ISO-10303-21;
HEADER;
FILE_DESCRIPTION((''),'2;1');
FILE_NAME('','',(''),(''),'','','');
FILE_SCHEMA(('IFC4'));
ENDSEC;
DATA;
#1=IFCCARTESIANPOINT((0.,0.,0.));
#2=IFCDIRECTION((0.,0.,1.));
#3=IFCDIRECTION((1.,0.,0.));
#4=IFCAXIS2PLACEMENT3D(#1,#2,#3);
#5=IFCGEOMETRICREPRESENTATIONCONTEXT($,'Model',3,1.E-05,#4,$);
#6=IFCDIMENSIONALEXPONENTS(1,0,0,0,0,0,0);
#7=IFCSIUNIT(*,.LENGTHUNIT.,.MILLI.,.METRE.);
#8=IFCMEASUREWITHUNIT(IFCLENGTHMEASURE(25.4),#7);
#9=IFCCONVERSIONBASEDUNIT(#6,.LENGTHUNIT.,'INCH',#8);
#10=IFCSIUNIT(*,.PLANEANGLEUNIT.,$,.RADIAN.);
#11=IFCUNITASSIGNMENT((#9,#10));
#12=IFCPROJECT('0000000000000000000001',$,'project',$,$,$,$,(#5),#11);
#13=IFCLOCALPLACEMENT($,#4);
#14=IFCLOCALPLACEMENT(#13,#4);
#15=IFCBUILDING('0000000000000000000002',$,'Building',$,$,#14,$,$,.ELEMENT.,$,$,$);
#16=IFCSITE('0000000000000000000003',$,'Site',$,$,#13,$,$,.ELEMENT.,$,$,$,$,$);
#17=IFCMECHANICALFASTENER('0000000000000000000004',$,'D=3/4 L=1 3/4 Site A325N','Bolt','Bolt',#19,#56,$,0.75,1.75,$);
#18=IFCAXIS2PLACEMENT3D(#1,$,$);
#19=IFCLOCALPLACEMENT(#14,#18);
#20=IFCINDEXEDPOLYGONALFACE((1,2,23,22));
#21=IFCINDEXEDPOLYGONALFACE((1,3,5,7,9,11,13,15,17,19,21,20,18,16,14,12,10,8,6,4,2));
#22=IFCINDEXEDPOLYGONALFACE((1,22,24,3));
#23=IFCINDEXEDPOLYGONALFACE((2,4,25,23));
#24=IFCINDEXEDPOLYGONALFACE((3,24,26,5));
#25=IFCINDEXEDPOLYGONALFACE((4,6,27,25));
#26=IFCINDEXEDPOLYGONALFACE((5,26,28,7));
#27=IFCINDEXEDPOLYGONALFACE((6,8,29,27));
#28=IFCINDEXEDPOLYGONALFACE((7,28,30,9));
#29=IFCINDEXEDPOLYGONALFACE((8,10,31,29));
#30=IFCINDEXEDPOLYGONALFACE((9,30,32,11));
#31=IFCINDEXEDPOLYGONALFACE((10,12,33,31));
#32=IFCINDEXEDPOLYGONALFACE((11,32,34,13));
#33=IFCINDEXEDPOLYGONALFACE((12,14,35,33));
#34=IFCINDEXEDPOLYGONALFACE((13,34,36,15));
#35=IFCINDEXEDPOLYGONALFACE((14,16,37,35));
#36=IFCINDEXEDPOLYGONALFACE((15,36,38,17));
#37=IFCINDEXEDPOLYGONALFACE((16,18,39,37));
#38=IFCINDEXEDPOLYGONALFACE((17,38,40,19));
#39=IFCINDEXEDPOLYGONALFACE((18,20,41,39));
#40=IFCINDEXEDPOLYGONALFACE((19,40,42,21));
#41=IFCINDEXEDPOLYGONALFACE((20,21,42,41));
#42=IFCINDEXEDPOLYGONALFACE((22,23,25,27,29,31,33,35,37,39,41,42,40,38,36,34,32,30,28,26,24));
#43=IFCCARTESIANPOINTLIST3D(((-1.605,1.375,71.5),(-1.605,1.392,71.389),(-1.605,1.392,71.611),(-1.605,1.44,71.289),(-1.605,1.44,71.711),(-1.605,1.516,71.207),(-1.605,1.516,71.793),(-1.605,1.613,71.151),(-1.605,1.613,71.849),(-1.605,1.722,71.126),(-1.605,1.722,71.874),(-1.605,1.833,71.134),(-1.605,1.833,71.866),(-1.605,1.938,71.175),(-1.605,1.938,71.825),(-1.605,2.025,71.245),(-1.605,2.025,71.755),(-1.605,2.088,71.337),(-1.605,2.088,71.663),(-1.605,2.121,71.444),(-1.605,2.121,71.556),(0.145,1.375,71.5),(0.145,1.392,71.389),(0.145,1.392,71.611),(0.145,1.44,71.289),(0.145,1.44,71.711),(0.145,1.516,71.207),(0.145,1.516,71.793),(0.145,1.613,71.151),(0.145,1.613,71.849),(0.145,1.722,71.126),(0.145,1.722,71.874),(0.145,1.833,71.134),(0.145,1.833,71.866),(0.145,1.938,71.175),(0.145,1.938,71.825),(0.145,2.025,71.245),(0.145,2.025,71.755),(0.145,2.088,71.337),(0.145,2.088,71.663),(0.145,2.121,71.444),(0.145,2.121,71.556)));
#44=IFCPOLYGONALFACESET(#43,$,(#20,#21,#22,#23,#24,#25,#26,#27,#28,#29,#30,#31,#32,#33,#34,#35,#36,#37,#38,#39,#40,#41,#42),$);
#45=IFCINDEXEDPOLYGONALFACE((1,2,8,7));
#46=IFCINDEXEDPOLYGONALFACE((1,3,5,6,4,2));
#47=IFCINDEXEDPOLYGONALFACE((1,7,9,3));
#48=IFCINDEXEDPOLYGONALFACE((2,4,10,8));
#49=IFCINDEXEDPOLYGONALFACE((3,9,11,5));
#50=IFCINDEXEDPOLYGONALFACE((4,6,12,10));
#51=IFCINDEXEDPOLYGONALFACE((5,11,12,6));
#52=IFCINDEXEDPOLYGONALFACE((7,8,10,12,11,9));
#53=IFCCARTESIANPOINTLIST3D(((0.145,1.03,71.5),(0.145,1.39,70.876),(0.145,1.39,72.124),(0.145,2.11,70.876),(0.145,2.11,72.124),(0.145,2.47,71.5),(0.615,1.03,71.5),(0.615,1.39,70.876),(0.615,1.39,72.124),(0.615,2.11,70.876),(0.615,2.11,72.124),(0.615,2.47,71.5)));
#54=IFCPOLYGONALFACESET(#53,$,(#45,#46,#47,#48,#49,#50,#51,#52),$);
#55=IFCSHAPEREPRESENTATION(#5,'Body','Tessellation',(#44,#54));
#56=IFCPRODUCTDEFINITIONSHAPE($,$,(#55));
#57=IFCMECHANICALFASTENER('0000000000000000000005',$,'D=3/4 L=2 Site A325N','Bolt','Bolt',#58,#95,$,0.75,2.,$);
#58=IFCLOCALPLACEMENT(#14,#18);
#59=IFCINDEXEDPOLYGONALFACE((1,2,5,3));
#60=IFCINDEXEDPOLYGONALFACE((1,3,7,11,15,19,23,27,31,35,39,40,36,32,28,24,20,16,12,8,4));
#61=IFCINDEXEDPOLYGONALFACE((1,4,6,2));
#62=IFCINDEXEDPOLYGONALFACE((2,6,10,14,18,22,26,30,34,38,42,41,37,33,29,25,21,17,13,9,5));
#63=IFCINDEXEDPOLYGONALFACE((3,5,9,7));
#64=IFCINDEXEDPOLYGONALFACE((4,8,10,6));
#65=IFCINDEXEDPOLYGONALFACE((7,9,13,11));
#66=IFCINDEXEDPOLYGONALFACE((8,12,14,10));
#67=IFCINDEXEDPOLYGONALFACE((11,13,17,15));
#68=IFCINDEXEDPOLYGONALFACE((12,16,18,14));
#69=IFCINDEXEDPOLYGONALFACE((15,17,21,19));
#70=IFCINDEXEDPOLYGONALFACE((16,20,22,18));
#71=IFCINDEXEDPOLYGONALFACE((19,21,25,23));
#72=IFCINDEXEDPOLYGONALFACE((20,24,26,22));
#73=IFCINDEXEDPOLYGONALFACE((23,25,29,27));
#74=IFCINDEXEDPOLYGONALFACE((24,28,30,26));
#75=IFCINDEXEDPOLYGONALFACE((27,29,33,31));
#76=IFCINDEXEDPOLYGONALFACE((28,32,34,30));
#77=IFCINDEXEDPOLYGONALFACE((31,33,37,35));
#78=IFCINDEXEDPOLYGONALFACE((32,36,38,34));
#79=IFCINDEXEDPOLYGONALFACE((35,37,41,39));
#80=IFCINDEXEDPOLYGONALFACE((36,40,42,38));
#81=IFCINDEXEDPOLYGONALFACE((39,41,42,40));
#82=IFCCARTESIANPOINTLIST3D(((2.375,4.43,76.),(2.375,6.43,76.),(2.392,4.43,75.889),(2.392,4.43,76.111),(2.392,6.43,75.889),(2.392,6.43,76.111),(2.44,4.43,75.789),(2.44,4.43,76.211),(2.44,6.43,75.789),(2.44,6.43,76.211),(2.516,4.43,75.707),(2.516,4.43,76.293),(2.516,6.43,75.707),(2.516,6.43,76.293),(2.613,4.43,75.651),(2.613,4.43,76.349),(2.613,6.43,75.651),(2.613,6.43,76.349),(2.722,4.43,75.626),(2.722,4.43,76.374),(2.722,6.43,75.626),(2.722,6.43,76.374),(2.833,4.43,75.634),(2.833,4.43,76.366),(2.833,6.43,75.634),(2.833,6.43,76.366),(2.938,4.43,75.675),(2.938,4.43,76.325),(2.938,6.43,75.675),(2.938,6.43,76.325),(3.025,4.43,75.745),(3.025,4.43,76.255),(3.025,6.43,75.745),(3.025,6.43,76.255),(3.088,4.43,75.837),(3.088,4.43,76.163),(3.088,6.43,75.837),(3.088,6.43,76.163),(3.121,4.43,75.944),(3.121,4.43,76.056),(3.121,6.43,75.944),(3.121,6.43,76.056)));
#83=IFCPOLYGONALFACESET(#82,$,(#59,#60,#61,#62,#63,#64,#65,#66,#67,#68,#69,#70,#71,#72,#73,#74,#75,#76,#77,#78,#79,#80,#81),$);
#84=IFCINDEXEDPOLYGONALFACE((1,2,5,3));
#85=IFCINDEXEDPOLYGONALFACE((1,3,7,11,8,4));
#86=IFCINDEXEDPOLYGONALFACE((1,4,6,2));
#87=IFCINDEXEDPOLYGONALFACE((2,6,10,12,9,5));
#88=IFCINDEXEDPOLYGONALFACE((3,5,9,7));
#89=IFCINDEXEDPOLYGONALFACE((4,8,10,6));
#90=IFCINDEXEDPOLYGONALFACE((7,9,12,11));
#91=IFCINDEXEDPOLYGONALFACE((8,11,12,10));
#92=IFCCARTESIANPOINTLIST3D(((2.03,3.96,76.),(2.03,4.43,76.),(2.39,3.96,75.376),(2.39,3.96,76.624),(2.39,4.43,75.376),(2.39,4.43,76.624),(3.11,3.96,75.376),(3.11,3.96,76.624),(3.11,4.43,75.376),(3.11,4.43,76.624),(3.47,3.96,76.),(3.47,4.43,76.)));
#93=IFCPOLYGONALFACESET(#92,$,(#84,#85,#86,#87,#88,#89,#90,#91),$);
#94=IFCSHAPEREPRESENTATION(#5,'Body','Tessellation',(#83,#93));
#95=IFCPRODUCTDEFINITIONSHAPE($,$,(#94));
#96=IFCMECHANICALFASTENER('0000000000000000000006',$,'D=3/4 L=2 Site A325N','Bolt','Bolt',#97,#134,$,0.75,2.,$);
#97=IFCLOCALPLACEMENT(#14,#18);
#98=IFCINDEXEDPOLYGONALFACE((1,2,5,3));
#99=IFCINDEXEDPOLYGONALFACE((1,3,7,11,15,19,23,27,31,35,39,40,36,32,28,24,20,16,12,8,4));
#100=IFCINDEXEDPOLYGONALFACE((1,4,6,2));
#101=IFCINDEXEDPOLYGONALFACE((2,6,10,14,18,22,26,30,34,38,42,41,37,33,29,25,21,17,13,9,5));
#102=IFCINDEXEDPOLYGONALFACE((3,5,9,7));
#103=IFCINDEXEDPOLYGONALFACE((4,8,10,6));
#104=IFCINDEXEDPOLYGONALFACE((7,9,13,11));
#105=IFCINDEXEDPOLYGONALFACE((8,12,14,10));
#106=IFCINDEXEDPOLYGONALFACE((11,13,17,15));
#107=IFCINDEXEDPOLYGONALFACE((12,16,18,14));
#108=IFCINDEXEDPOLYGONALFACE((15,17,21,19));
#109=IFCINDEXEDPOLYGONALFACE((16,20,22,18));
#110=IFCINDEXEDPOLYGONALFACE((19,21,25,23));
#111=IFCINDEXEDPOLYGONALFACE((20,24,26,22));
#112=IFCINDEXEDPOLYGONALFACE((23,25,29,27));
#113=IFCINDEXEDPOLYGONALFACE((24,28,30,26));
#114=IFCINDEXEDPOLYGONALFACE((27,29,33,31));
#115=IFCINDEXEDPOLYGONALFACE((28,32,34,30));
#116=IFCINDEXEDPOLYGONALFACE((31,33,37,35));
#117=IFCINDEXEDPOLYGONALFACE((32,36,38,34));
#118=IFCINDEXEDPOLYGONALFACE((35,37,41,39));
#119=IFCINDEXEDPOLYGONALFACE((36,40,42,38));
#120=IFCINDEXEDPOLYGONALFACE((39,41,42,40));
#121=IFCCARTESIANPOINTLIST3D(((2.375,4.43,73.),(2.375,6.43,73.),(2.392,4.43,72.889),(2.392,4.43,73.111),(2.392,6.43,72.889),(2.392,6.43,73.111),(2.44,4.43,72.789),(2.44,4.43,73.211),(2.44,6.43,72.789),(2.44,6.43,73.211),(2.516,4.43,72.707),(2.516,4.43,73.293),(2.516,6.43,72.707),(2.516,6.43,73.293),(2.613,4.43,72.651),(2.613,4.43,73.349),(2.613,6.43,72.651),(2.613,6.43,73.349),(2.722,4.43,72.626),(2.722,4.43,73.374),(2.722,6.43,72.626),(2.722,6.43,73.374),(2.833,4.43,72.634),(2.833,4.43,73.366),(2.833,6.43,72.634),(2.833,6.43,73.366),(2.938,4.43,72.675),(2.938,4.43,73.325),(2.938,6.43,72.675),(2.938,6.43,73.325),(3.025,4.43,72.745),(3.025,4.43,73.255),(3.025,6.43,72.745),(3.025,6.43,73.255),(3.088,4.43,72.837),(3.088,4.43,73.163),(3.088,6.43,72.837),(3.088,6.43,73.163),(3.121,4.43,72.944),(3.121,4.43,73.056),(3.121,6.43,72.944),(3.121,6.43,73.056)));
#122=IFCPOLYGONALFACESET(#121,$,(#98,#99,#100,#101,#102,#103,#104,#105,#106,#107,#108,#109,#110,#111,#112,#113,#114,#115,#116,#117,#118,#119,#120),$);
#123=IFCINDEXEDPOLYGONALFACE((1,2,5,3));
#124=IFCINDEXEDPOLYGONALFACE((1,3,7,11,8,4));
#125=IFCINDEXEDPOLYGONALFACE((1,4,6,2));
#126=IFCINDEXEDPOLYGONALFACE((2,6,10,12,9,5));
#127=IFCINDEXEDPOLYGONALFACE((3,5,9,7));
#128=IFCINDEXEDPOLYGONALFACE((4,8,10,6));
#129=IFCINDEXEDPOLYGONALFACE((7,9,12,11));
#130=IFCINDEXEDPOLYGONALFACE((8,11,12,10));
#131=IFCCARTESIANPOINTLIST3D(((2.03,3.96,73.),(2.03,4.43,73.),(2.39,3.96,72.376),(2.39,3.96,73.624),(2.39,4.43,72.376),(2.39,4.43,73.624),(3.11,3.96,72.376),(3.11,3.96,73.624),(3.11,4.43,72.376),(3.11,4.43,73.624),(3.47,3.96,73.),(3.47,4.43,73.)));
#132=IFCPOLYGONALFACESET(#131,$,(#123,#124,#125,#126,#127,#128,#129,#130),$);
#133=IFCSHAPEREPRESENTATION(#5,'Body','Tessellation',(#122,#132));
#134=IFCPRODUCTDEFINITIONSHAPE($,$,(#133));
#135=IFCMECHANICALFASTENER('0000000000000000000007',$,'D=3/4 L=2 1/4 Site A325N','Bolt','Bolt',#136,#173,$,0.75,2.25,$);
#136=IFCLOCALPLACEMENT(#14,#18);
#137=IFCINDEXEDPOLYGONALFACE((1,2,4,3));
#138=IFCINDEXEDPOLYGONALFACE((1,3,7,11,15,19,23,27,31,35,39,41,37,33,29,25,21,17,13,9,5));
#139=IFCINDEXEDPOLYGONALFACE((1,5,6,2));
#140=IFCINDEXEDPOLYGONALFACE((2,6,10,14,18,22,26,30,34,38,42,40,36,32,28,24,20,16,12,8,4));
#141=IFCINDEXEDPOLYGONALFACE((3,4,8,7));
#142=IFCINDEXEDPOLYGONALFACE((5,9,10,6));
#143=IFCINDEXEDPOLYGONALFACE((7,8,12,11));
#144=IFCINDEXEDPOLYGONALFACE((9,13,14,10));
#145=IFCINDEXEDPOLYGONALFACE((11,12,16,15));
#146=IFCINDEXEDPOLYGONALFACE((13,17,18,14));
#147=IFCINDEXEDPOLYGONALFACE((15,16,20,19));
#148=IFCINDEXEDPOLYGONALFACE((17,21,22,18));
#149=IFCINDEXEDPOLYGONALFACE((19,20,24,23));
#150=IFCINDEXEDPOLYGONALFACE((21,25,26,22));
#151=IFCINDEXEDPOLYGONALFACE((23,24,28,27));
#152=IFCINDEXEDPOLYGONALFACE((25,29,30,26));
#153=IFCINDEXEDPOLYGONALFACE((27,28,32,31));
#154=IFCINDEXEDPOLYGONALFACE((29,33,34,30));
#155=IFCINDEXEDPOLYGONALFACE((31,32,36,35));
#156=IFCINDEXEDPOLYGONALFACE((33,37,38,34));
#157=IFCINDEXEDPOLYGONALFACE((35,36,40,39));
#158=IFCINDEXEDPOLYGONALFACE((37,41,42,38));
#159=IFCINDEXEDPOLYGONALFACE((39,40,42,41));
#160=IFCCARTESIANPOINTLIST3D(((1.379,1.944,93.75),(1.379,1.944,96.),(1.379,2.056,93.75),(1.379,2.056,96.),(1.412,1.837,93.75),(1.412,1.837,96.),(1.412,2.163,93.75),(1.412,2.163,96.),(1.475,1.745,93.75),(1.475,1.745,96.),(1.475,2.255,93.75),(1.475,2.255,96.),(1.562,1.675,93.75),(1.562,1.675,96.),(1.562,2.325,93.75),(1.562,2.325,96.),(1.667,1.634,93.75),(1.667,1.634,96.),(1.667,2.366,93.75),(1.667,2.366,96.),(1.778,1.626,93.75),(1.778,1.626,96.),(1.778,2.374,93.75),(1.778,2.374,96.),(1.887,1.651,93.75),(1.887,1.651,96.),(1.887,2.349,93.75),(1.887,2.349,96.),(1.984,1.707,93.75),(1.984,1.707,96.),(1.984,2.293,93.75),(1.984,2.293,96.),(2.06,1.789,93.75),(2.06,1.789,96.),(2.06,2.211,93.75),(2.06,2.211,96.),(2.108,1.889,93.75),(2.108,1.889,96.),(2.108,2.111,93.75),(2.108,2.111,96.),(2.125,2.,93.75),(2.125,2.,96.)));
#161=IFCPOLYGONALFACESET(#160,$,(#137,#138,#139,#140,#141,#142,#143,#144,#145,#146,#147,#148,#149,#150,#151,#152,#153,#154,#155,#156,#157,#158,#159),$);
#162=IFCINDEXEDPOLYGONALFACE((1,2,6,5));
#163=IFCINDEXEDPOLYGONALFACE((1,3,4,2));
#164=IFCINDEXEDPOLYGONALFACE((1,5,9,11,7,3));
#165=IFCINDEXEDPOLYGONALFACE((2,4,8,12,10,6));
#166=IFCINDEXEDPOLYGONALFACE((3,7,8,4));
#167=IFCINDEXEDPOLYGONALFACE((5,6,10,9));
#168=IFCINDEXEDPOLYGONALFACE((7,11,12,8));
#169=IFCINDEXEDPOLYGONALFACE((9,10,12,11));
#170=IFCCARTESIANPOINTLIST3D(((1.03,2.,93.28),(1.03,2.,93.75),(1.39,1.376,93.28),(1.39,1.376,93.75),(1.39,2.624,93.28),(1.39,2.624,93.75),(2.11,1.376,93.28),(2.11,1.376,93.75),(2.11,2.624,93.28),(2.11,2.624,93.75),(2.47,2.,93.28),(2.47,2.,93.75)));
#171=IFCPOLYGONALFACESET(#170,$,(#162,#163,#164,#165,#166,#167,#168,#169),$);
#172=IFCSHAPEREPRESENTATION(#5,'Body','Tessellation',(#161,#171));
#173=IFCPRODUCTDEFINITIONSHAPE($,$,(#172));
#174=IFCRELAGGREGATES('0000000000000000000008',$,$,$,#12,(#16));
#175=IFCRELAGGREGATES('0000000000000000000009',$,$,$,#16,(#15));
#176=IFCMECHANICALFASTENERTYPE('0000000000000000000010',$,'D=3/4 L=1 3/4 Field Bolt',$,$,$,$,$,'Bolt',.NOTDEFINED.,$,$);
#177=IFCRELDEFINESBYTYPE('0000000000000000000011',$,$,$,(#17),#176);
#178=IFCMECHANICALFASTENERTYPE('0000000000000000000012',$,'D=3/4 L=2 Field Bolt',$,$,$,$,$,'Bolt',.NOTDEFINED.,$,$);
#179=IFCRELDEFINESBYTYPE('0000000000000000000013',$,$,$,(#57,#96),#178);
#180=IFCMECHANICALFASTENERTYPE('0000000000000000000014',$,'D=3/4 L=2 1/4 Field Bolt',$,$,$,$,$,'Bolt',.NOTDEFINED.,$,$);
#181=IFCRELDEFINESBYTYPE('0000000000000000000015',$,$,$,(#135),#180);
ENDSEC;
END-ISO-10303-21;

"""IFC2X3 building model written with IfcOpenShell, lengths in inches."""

from ifc_helpers import new_model, entity, si_unit, converted_unit, frame, origin_with_axes, origin_2d_with_axis, place, context, project, spatial, polyline, circle, outline, extrude, source, transform, mapped, type_object, type_shapes, element, save


model = new_model("IFC2X3")

# Units and contexts
model_context = context("Model", 3, precision=1e-05, world=origin_with_axes())
ifc_project = project(units=[converted_unit("LENGTHUNIT", "INCH", entity("IfcLengthMeasure", 25.4), si_unit("LENGTHUNIT", "METRE", prefix="MILLI"), dimensions=[1, 0, 0, 0, 0, 0, 0]), si_unit("PLANEANGLEUNIT", "RADIAN")], contexts=[model_context])

# Site, building
site_placement = place(None, origin_with_axes())
site = spatial("IfcSite", under=ifc_project, at=site_placement, Name="Site", CompositionType="ELEMENT")
building_placement = place(site_placement, origin_with_axes())
building = spatial("IfcBuilding", under=site, at=building_placement, Name="Building", CompositionType="ELEMENT")

# Shared definitions
assembly_1_placement = place(building_placement, frame((0.0, 0.0, 54.5), z_axis=(0.0, -1.0, 0.0), x_axis=(0.0, 0.0, 1.0)))

# Shared definitions
assembly_2_placement = place(building_placement, frame((0.0, 0.0, 80.0), z_axis=(0.0, 0.0, 1.0), x_axis=(0.0, 1.0, 0.0)))

# Mechanical fasteners
mechanical_fastener_type_1 = type_object("IfcMechanicalFastenerType", Name="D=3/4 L=1 3/4 Field Bolt", ElementType="Bolt")
shared_shape_1 = source(origin_with_axes(), model_context, "Body", "SweptSolid", [
    extrude(circle(Radius=0.375, at=origin_2d_with_axis()), frame((0.0, 0.0, 0.0), z_axis=(1.0, 0.0, 0.0), x_axis=(0.0, 1.0, 0.0)), (0.0, 0.0, 1.0), 1.75),
    extrude(outline(polyline([(-0.72, 0.0), (-0.36, 0.624), (0.36, 0.624), (0.72, 0.0), (0.36, -0.624), (-0.36, -0.624), (-0.72, 0.0)])), frame((0.0, 0.0, 0.0), z_axis=(1.0, 0.0, 0.0), x_axis=(0.0, 1.0, 0.0)), (0.0, 0.0, -1.0), 0.47),
])
type_shapes(mechanical_fastener_type_1, [shared_shape_1])
placement_1 = place(building_placement, frame((0.0, 0.0, 80.0), z_axis=(0.0, 0.0, 1.0), x_axis=(-1.0, 0.0, 0.0)))
placement_2 = place(placement_1, frame((-0.145, -1.75, -11.5), z_axis=(0.0, 0.0, 1.0), x_axis=(1.0, 0.0, 0.0)))
for number, where, z_axis, x_axis, name in (
    (1, (0.0, 0.0, 3.0), (0.0, 0.0, 1.0), (1.0, 0.0, 0.0), "D=3/4 L=1 3/4 Site A325N"),
):
    element("IfcMechanicalFastener", number, at=place(placement_2, frame(where, z_axis=z_axis, x_axis=x_axis)), type_object=mechanical_fastener_type_1, Name=name, Description="Bolt", ObjectType="Bolt", NominalDiameter=0.75, NominalLength=1.75, context=model_context, shape_type="MappedRepresentation", body=[
        mapped(shared_shape_1, transform((0.0, 0.0, 0.0), scale=1.0)),
    ])
mechanical_fastener_type_2 = type_object("IfcMechanicalFastenerType", Name="D=3/4 L=2 Field Bolt", ElementType="Bolt")
shared_shape_2 = source(origin_with_axes(), model_context, "Body", "SweptSolid", [
    extrude(circle(Radius=0.375, at=origin_2d_with_axis()), frame((0.0, 0.0, 0.0), z_axis=(1.0, 0.0, 0.0), x_axis=(0.0, 1.0, 0.0)), (0.0, 0.0, 1.0), 2.0),
    extrude(outline(polyline([(-0.72, 0.0), (-0.36, 0.624), (0.36, 0.624), (0.72, 0.0), (0.36, -0.624), (-0.36, -0.624), (-0.72, 0.0)])), frame((0.0, 0.0, 0.0), z_axis=(1.0, 0.0, 0.0), x_axis=(0.0, 1.0, 0.0)), (0.0, 0.0, -1.0), 0.47),
])
type_shapes(mechanical_fastener_type_2, [shared_shape_2])
placement_3 = place(assembly_2_placement, frame((4.43, -2.75, -10.0), z_axis=(0.0, 0.0, 1.0), x_axis=(1.0, 0.0, 0.0)))
for number, where, z_axis, x_axis, name in (
    (2, (0.0, 0.0, 6.0), (0.0, 0.0, 1.0), (1.0, 0.0, 0.0), "D=3/4 L=2 Site A325N"),
    (3, (0.0, 0.0, 3.0), (0.0, 0.0, 1.0), (1.0, 0.0, 0.0), "D=3/4 L=2 Site A325N"),
):
    element("IfcMechanicalFastener", number, at=place(placement_3, frame(where, z_axis=z_axis, x_axis=x_axis)), type_object=mechanical_fastener_type_2, Name=name, Description="Bolt", ObjectType="Bolt", NominalDiameter=0.75, NominalLength=2.0, context=model_context, shape_type="MappedRepresentation", body=[
        mapped(shared_shape_2, transform((0.0, 0.0, 0.0), scale=1.0)),
    ])
mechanical_fastener_type_3 = type_object("IfcMechanicalFastenerType", Name="D=3/4 L=2 1/4 Field Bolt", ElementType="Bolt")
shared_shape_3 = source(origin_with_axes(), model_context, "Body", "SweptSolid", [
    extrude(circle(Radius=0.375, at=origin_2d_with_axis()), frame((0.0, 0.0, 0.0), z_axis=(1.0, 0.0, 0.0), x_axis=(0.0, 1.0, 0.0)), (0.0, 0.0, 1.0), 2.25),
    extrude(outline(polyline([(-0.72, 0.0), (-0.36, 0.624), (0.36, 0.624), (0.72, 0.0), (0.36, -0.624), (-0.36, -0.624), (-0.72, 0.0)])), frame((0.0, 0.0, 0.0), z_axis=(1.0, 0.0, 0.0), x_axis=(0.0, 1.0, 0.0)), (0.0, 0.0, -1.0), 0.47),
])
type_shapes(mechanical_fastener_type_3, [shared_shape_3])
placement_4 = place(assembly_1_placement, frame((39.25, -1.75, -2.0), z_axis=(0.0, 0.0, -1.0), x_axis=(1.0, 0.0, 0.0)))
mechanical_fastener_placement = place(placement_4, origin_with_axes())
element("IfcMechanicalFastener", 4, at=mechanical_fastener_placement, type_object=mechanical_fastener_type_3, Name="D=3/4 L=2 1/4 Site A325N", Description="Bolt", ObjectType="Bolt", NominalDiameter=0.75, NominalLength=2.25, context=model_context, shape_type="MappedRepresentation", body=[
    mapped(shared_shape_3, transform((0.0, 0.0, 0.0), scale=1.0)),
])

save(model, "model.ifc")
